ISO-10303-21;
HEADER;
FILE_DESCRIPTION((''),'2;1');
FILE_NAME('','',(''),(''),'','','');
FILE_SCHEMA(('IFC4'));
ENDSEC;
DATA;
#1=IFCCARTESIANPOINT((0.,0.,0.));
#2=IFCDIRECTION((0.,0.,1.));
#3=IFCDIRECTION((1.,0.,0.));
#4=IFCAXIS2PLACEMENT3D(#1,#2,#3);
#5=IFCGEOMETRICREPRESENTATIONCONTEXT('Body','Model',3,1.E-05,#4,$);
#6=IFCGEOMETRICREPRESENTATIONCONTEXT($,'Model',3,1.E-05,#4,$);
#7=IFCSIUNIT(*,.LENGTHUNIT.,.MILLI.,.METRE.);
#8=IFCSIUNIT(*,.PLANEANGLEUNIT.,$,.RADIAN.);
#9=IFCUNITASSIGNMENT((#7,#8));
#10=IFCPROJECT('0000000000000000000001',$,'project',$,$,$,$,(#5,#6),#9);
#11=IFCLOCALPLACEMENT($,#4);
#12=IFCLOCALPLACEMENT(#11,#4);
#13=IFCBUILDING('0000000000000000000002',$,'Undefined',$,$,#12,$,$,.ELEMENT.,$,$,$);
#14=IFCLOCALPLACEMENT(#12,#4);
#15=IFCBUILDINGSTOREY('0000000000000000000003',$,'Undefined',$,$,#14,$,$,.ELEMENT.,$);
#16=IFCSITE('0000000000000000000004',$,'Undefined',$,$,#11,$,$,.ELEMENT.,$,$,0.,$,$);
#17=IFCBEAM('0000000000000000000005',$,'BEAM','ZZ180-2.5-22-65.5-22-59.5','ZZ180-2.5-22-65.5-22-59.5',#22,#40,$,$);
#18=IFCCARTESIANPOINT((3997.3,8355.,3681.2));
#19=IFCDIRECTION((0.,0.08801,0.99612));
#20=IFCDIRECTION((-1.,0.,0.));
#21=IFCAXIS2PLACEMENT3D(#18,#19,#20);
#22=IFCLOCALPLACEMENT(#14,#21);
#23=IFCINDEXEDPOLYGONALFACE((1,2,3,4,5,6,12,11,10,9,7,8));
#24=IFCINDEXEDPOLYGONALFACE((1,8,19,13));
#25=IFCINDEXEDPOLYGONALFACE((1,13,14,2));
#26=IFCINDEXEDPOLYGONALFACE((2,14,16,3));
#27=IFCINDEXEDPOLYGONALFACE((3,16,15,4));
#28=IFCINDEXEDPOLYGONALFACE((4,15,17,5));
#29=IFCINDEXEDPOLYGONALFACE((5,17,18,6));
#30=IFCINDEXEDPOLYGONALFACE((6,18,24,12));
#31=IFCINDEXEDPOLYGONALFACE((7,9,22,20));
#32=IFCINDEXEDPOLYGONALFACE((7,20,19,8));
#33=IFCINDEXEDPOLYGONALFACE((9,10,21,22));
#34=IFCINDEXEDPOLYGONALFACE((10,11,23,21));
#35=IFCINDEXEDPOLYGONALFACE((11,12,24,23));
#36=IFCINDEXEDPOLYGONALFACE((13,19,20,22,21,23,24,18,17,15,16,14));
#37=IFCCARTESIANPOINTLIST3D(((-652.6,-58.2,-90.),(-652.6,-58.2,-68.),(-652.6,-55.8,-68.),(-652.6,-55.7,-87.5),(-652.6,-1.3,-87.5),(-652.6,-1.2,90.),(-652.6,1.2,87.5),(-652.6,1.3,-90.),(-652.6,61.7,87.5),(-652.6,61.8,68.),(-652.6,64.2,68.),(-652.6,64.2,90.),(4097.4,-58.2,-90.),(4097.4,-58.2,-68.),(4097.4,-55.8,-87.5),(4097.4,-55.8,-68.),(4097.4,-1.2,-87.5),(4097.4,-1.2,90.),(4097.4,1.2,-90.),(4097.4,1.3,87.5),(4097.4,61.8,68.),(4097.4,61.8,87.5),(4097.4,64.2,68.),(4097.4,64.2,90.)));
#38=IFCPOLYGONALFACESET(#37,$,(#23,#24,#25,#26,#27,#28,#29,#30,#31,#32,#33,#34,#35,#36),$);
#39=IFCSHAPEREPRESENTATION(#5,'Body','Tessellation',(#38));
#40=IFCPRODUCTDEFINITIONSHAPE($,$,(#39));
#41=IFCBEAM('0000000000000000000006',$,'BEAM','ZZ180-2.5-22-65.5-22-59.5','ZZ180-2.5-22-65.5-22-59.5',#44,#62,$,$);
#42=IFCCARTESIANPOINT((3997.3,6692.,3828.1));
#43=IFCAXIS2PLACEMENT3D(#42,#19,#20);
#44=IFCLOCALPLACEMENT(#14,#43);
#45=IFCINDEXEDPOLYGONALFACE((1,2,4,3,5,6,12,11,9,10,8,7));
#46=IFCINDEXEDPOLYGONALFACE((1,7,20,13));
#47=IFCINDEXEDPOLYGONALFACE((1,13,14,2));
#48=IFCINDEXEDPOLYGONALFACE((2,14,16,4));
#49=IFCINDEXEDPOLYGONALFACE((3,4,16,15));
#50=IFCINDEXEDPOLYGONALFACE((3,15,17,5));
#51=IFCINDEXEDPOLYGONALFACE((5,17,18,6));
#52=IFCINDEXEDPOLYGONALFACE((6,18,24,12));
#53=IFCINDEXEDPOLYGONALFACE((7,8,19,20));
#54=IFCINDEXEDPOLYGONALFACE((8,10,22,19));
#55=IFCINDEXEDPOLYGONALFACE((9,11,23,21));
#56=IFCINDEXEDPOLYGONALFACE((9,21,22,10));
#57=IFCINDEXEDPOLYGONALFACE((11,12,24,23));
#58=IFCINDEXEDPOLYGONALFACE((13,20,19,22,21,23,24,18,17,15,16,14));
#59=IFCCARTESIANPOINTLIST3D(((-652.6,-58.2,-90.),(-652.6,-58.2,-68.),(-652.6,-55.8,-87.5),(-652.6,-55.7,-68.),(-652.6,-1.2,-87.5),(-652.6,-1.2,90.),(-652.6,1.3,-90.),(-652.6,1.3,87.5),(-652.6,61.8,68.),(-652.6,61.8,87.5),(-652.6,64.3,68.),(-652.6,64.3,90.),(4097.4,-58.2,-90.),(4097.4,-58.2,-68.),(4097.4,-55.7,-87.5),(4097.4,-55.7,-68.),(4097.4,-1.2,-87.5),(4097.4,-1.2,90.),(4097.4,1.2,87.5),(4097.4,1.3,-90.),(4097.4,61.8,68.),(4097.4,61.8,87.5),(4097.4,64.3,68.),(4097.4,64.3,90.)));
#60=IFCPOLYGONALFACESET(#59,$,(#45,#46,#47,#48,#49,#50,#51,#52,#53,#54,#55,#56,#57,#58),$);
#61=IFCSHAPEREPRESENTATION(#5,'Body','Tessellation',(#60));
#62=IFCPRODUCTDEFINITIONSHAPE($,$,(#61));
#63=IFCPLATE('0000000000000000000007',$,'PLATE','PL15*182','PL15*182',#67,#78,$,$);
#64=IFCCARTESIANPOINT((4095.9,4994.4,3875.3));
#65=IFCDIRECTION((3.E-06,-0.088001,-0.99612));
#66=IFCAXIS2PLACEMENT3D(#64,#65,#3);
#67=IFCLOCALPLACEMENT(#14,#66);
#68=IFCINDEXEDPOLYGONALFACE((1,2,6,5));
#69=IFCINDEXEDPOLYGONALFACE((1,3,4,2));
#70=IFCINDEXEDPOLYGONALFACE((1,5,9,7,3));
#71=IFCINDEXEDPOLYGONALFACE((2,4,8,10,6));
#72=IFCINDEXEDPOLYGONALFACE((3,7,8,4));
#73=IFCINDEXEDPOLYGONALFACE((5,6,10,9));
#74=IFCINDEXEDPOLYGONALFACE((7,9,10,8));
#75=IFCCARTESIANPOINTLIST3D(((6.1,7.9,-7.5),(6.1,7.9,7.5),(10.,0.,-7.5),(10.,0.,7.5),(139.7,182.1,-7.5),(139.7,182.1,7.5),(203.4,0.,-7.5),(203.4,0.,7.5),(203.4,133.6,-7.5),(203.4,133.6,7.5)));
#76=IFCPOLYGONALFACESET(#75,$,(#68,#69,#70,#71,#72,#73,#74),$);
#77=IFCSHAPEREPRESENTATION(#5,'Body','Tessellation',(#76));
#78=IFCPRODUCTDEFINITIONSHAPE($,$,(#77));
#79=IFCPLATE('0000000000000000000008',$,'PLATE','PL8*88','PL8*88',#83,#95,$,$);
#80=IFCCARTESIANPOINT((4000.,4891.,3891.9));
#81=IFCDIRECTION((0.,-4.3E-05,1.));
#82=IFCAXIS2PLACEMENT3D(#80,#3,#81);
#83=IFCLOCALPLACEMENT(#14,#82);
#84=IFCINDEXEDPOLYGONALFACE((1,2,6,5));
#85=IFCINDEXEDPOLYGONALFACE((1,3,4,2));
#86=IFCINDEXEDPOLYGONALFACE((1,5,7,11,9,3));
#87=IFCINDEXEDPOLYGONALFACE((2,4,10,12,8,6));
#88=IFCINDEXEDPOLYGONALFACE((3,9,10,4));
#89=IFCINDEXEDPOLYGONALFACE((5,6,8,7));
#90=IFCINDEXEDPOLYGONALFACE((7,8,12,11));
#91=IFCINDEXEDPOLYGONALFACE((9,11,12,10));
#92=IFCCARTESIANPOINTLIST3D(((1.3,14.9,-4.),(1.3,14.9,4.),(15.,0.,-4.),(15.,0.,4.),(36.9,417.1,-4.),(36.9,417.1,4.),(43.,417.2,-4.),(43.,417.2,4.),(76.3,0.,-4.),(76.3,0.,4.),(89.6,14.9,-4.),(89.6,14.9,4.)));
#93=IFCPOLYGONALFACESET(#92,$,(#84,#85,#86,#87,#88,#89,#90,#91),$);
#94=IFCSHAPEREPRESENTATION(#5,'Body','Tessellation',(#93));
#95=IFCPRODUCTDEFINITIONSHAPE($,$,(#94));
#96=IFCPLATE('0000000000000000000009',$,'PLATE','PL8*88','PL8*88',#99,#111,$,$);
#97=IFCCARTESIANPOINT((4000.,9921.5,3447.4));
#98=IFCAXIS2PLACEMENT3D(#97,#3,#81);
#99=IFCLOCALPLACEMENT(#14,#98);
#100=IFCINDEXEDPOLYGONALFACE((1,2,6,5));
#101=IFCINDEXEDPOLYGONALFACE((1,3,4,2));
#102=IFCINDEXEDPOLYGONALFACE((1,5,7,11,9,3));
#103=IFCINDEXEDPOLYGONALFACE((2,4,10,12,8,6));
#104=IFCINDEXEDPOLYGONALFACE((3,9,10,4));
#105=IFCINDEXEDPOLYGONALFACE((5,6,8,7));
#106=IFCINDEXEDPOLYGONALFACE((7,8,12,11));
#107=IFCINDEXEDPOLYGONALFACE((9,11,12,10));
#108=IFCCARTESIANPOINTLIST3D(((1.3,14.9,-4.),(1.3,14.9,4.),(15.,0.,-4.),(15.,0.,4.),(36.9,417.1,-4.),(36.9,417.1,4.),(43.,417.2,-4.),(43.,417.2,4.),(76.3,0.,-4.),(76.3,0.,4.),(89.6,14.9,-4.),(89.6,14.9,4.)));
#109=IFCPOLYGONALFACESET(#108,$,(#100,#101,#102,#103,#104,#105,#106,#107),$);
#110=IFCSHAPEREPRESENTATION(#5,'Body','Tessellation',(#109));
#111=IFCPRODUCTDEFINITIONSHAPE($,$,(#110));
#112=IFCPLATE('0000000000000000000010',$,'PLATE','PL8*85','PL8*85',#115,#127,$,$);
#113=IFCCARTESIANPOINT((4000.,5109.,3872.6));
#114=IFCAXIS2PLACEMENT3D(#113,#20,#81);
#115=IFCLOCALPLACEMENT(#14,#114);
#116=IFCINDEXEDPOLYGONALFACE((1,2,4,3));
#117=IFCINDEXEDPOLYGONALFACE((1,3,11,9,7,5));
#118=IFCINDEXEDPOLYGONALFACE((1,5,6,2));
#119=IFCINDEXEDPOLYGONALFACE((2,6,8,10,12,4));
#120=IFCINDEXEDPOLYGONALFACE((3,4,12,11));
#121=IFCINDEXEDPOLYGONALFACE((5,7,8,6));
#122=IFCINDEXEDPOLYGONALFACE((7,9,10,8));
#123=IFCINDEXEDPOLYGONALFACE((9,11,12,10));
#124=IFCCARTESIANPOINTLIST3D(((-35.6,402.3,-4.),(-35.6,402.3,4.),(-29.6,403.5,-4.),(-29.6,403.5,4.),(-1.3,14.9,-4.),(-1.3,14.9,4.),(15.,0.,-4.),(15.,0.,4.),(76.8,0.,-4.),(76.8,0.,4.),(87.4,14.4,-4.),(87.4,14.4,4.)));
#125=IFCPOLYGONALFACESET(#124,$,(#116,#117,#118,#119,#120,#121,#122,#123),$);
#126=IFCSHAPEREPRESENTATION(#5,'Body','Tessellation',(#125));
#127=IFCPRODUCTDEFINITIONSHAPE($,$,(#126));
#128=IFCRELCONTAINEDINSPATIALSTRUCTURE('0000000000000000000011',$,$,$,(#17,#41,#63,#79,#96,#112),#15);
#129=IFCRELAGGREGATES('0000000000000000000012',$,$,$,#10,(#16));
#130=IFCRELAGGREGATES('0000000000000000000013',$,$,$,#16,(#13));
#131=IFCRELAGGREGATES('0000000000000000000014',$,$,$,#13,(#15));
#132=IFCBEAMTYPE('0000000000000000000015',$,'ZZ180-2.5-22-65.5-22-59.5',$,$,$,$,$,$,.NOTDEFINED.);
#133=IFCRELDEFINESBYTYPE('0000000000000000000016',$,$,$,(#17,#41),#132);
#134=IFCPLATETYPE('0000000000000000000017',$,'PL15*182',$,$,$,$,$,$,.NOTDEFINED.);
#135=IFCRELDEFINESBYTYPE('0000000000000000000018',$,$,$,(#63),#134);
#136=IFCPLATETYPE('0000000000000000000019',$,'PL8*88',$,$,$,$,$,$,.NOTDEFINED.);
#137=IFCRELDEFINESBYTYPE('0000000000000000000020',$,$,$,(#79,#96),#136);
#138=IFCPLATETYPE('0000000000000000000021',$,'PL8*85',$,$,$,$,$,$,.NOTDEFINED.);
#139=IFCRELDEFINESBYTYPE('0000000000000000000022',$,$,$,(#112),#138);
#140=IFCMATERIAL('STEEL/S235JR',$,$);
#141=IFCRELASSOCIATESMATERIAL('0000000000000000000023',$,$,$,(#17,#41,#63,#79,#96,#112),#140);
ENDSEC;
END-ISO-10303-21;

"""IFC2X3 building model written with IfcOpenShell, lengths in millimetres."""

from ifc_helpers import new_model, si_unit, frame, origin_with_axes, place, context, project, spatial, polyline, outline, extrude, material, type_object, element, save


model = new_model("IFC2X3")

# Units and contexts
model_context_1 = context("Model", 3, precision=1e-05, world=origin_with_axes(), identifier="Body")
model_context_2 = context("Model", 3, precision=1e-05, world=origin_with_axes())
ifc_project = project(units=[si_unit("LENGTHUNIT", "METRE", prefix="MILLI"), si_unit("PLANEANGLEUNIT", "RADIAN")], contexts=[model_context_1, model_context_2])

# Site, building, storey
site_placement = place(None, origin_with_axes())
site = spatial("IfcSite", under=ifc_project, at=site_placement, Name="Undefined", CompositionType="ELEMENT", RefElevation=0.0)
building_placement = place(site_placement, origin_with_axes())
building = spatial("IfcBuilding", under=site, at=building_placement, Name="Undefined", CompositionType="ELEMENT")
storey_placement = place(building_placement, origin_with_axes())
storey = spatial("IfcBuildingStorey", under=building, at=storey_placement, Name="Undefined", CompositionType="ELEMENT")

# Shared definitions
ifc_material = material(Name="STEEL/S235JR")

# Beams
beam_type_1 = type_object("IfcBeamType", Name="ZZ180-2.5-22-65.5-22-59.5", PredefinedType="NOTDEFINED")
for number, where, z_axis, x_axis, name in (
    (1, (3997.3, 8355.0, 3681.2), (0.0, 0.08801, 0.99612), (-1.0, 0.0, 0.0), "BEAM"),
    (2, (3997.3, 6692.0, 3828.1), (0.0, 0.08801, 0.99612), (-1.0, 0.0, 0.0), "BEAM"),
):
    element("IfcBeam", number, at=place(storey_placement, frame(where, z_axis=z_axis, x_axis=x_axis)), inside=storey, type_object=beam_type_1, material=ifc_material, Name=name, Description="ZZ180-2.5-22-65.5-22-59.5", ObjectType="ZZ180-2.5-22-65.5-22-59.5", context=model_context_1, shape_type="SweptSolid", body=[
        extrude(outline(polyline([(58.2, -90.0), (58.2, -68.0), (55.8, -68.0), (55.8, -87.5), (1.2, -87.5), (1.2, 90.0), (-64.2, 90.0), (-64.2, 68.0), (-61.8, 68.0), (-61.8, 87.5), (-1.2, 87.5), (-1.2, -90.0), (58.2, -90.0)])), frame((4097.4, 0.0, 0.0), z_axis=(-1.0, 0.0, 0.0), x_axis=(0.0, -1.0, 0.0)), (0.0, 0.0, 1.0), 4750.0),
    ])

# Plates
plate_type_1 = type_object("IfcPlateType", Name="PL15*182", PredefinedType="NOTDEFINED")
plate_1_placement = place(storey_placement, frame((4095.9, 4994.4, 3875.3), z_axis=(0.000003, -0.088001, -0.99612), x_axis=(1.0, 0.0, 0.0)))
element("IfcPlate", 3, at=plate_1_placement, inside=storey, type_object=plate_type_1, material=ifc_material, Name="PLATE", Description="PL15*182", ObjectType="PL15*182", context=model_context_1, shape_type="SweptSolid", body=[
    extrude(outline(polyline([(6.1, 7.9), (10.0, 0.0), (203.4, 0.0), (203.4, 133.6), (139.7, 182.1), (6.1, 7.9)])), frame((0.0, 0.0, -7.5), z_axis=(0.0, 0.0, 1.0), x_axis=(1.0, 0.0, 0.0)), (0.0, 0.0, 1.0), 15.0),
])
plate_type_2 = type_object("IfcPlateType", Name="PL8*88", PredefinedType="NOTDEFINED")
plate_2_placement = place(storey_placement, frame((4000.0, 4891.0, 3891.9), z_axis=(1.0, 0.0, 0.0), x_axis=(0.0, -0.000043, 1.0)))
element("IfcPlate", 4, at=plate_2_placement, inside=storey, type_object=plate_type_2, material=ifc_material, Name="PLATE", Description="PL8*88", ObjectType="PL8*88", context=model_context_1, shape_type="SweptSolid", body=[
    extrude(outline(polyline([(1.3, 14.9), (15.0, 0.0), (76.3, 0.0), (89.6, 14.9), (43.0, 417.2), (36.9, 417.1), (1.3, 14.9)])), frame((0.0, 0.0, -4.0), z_axis=(0.0, 0.0, 1.0), x_axis=(1.0, 0.0, 0.0)), (0.0, 0.0, 1.0), 8.0),
])
plate_3_placement = place(storey_placement, frame((4000.0, 9921.5, 3447.4), z_axis=(1.0, 0.0, 0.0), x_axis=(0.0, -0.000043, 1.0)))
element("IfcPlate", 5, at=plate_3_placement, inside=storey, type_object=plate_type_2, material=ifc_material, Name="PLATE", Description="PL8*88", ObjectType="PL8*88", context=model_context_1, shape_type="SweptSolid", body=[
    extrude(outline(polyline([(1.3, 14.9), (15.0, 0.0), (76.3, 0.0), (89.6, 14.9), (43.0, 417.2), (36.9, 417.1), (1.3, 14.9)])), frame((0.0, 0.0, -4.0), z_axis=(0.0, 0.0, 1.0), x_axis=(1.0, 0.0, 0.0)), (0.0, 0.0, 1.0), 8.0),
])
plate_type_3 = type_object("IfcPlateType", Name="PL8*85", PredefinedType="NOTDEFINED")
plate_4_placement = place(storey_placement, frame((4000.0, 5109.0, 3872.6), z_axis=(-1.0, 0.0, 0.0), x_axis=(0.0, -0.000043, 1.0)))
element("IfcPlate", 6, at=plate_4_placement, inside=storey, type_object=plate_type_3, material=ifc_material, Name="PLATE", Description="PL8*85", ObjectType="PL8*85", context=model_context_1, shape_type="SweptSolid", body=[
    extrude(outline(polyline([(-1.3, 14.9), (15.0, 0.0), (76.8, 0.0), (87.4, 14.4), (-29.6, 403.5), (-35.6, 402.3), (-1.3, 14.9)])), frame((0.0, 0.0, -4.0), z_axis=(0.0, 0.0, 1.0), x_axis=(1.0, 0.0, 0.0)), (0.0, 0.0, 1.0), 8.0),
])

save(model, "model.ifc")
